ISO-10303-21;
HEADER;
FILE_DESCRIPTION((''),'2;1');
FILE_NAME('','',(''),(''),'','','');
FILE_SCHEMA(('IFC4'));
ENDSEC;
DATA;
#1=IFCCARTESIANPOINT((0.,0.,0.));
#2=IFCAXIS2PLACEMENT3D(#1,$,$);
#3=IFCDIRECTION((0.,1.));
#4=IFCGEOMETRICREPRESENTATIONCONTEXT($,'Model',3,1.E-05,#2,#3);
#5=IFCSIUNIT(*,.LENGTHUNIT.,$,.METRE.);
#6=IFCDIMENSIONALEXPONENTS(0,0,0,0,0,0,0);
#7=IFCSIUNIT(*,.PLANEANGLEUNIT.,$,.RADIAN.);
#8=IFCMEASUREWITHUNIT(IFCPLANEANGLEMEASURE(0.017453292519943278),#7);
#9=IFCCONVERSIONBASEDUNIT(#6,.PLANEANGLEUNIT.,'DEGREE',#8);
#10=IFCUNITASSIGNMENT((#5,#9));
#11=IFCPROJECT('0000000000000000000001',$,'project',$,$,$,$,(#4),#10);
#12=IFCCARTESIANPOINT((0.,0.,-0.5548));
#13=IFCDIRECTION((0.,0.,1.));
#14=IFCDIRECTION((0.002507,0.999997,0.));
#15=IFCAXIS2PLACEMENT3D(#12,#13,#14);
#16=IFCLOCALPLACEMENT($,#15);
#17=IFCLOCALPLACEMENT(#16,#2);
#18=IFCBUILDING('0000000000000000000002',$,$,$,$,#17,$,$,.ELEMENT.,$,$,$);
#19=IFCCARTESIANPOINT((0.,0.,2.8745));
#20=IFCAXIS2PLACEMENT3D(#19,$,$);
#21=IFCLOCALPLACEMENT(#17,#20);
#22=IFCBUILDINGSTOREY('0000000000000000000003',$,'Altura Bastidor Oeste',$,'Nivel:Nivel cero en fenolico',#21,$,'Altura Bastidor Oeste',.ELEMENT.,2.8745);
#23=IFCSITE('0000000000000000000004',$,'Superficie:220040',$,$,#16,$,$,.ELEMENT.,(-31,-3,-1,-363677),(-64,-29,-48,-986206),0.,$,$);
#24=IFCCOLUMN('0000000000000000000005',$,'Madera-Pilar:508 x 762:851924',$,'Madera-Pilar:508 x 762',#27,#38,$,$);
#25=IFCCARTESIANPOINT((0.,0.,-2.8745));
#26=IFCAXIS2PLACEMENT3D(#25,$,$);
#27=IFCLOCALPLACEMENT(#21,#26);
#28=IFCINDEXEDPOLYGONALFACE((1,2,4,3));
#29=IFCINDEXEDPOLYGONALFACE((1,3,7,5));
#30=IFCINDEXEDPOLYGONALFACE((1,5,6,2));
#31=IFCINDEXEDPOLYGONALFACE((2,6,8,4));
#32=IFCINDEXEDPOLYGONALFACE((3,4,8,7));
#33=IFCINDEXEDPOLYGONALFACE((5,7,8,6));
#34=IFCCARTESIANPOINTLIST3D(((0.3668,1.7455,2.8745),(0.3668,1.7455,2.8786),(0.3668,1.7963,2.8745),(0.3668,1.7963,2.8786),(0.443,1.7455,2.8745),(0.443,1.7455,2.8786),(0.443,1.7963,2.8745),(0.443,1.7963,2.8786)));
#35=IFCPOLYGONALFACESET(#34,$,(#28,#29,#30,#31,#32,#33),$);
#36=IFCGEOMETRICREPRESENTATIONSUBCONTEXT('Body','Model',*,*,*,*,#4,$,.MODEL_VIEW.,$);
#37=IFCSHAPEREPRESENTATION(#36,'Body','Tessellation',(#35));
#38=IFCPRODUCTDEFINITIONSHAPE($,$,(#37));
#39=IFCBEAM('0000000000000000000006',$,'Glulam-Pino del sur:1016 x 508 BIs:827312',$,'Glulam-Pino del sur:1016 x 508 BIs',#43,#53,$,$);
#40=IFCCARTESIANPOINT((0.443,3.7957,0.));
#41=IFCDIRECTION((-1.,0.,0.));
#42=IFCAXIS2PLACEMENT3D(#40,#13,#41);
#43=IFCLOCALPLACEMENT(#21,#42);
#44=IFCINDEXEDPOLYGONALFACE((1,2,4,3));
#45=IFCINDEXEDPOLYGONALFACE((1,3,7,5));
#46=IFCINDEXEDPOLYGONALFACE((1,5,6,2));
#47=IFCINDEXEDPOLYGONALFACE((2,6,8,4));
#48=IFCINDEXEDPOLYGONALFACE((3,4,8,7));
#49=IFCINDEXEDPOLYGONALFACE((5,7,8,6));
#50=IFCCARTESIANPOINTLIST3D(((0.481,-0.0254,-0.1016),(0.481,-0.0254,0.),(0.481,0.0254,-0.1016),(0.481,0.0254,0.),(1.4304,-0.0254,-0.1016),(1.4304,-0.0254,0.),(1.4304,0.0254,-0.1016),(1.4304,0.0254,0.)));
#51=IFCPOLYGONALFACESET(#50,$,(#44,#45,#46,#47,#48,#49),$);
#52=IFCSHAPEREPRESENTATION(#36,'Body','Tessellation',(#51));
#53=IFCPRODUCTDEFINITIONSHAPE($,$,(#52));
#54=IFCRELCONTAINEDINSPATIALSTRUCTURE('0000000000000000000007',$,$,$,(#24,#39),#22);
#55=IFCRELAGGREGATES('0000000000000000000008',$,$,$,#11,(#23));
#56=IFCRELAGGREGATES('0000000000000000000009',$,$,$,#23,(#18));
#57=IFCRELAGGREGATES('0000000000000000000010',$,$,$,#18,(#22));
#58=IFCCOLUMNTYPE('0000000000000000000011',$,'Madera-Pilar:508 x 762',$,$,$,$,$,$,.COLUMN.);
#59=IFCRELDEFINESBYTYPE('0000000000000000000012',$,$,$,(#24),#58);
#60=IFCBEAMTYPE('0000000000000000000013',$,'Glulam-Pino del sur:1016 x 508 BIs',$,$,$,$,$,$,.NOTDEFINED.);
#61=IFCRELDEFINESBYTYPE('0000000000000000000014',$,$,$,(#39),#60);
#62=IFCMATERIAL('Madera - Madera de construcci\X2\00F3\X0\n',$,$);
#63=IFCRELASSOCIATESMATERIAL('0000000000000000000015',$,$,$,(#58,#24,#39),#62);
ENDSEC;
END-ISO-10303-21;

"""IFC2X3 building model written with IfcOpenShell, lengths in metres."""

from ifc_helpers import new_model, entity, si_unit, converted_unit, direction, frame, frame_2d, origin, origin_2d_with_axis, place, context, subcontext, project, spatial, rectangle, extrude, source, transform, mapped, material, type_object, type_shapes, element, save


model = new_model("IFC2X3")

# Units and contexts
model_context = context("Model", 3, precision=1e-05, world=origin(), true_north=direction((0.0, 1.0)))
body_context = subcontext(model_context, "Body", "Model", "MODEL_VIEW")
ifc_project = project(units=[si_unit("LENGTHUNIT", "METRE"), converted_unit("PLANEANGLEUNIT", "DEGREE", entity("IfcPlaneAngleMeasure", 0.017453292519943278), si_unit("PLANEANGLEUNIT", "RADIAN"), dimensions=[0, 0, 0, 0, 0, 0, 0])], contexts=[model_context])

# Site, building, storey
site_placement = place(None, frame((0.0, 0.0, -0.5548), z_axis=(0.0, 0.0, 1.0), x_axis=(0.002507, 0.999997, 0.0)))
site = spatial("IfcSite", under=ifc_project, at=site_placement, Name="Superficie:220040", CompositionType="ELEMENT", RefLatitude=(-31, -3, -1, -363677), RefLongitude=(-64, -29, -48, -986206), RefElevation=0.0)
building_placement = place(site_placement, origin())
building = spatial("IfcBuilding", under=site, at=building_placement, CompositionType="ELEMENT")
storey_placement = place(building_placement, frame((0.0, 0.0, 2.8745)))
storey = spatial("IfcBuildingStorey", under=building, at=storey_placement, Name="Altura Bastidor Oeste", ObjectType="Nivel:Nivel cero en fenolico", LongName="Altura Bastidor Oeste", CompositionType="ELEMENT", Elevation=2.8745)

# Column
ifc_material_1 = material(Name="Madera - Madera de construcción")
column_type_1 = type_object("IfcColumnType", Name="Madera-Pilar:508 x 762", PredefinedType="COLUMN", material=ifc_material_1)
shared_shape_1 = source(origin(), body_context, "Body", "SweptSolid", [
    extrude(rectangle(XDim=0.0762, YDim=0.0508, at=origin_2d_with_axis()), frame((0.4049, 1.7709, 2.8745), z_axis=(0.0, 0.0, 1.0), x_axis=(-1.0, 0.0, 0.0)), (0.0, 0.0, 1.0), 0.0041),
])
type_shapes(column_type_1, [shared_shape_1])
column_1_placement = place(storey_placement, frame((0.0, 0.0, -2.8745)))
element("IfcColumn", 1, at=column_1_placement, inside=storey, type_object=column_type_1, material=ifc_material_1, Name="Madera-Pilar:508 x 762:851924", ObjectType="Madera-Pilar:508 x 762", context=body_context, shape_type="MappedRepresentation", body=[
    mapped(shared_shape_1, transform((0.0, 0.0, 0.0), scale=1.0)),
])

# Beam
beam_type_1 = type_object("IfcBeamType", Name="Glulam-Pino del sur:1016 x 508 BIs", PredefinedType="NOTDEFINED")
beam_1_placement = place(storey_placement, frame((0.443, 3.7957, 0.0), z_axis=(0.0, 0.0, 1.0), x_axis=(-1.0, 0.0, 0.0)))
element("IfcBeam", 2, at=beam_1_placement, inside=storey, type_object=beam_type_1, material=ifc_material_1, Name="Glulam-Pino del sur:1016 x 508 BIs:827312", ObjectType="Glulam-Pino del sur:1016 x 508 BIs", context=body_context, shape_type="SweptSolid", body=[
    extrude(rectangle(XDim=0.1016, YDim=0.0508, at=frame_2d((0.0, 0.0), x_axis=(1.0, 0.0))), frame((0.481, 0.0, -0.0508), z_axis=(1.0, 0.0, 0.0), x_axis=(0.0, 0.0, -1.0)), (0.0, 0.0, 1.0), 0.9494),
])

save(model, "model.ifc")
